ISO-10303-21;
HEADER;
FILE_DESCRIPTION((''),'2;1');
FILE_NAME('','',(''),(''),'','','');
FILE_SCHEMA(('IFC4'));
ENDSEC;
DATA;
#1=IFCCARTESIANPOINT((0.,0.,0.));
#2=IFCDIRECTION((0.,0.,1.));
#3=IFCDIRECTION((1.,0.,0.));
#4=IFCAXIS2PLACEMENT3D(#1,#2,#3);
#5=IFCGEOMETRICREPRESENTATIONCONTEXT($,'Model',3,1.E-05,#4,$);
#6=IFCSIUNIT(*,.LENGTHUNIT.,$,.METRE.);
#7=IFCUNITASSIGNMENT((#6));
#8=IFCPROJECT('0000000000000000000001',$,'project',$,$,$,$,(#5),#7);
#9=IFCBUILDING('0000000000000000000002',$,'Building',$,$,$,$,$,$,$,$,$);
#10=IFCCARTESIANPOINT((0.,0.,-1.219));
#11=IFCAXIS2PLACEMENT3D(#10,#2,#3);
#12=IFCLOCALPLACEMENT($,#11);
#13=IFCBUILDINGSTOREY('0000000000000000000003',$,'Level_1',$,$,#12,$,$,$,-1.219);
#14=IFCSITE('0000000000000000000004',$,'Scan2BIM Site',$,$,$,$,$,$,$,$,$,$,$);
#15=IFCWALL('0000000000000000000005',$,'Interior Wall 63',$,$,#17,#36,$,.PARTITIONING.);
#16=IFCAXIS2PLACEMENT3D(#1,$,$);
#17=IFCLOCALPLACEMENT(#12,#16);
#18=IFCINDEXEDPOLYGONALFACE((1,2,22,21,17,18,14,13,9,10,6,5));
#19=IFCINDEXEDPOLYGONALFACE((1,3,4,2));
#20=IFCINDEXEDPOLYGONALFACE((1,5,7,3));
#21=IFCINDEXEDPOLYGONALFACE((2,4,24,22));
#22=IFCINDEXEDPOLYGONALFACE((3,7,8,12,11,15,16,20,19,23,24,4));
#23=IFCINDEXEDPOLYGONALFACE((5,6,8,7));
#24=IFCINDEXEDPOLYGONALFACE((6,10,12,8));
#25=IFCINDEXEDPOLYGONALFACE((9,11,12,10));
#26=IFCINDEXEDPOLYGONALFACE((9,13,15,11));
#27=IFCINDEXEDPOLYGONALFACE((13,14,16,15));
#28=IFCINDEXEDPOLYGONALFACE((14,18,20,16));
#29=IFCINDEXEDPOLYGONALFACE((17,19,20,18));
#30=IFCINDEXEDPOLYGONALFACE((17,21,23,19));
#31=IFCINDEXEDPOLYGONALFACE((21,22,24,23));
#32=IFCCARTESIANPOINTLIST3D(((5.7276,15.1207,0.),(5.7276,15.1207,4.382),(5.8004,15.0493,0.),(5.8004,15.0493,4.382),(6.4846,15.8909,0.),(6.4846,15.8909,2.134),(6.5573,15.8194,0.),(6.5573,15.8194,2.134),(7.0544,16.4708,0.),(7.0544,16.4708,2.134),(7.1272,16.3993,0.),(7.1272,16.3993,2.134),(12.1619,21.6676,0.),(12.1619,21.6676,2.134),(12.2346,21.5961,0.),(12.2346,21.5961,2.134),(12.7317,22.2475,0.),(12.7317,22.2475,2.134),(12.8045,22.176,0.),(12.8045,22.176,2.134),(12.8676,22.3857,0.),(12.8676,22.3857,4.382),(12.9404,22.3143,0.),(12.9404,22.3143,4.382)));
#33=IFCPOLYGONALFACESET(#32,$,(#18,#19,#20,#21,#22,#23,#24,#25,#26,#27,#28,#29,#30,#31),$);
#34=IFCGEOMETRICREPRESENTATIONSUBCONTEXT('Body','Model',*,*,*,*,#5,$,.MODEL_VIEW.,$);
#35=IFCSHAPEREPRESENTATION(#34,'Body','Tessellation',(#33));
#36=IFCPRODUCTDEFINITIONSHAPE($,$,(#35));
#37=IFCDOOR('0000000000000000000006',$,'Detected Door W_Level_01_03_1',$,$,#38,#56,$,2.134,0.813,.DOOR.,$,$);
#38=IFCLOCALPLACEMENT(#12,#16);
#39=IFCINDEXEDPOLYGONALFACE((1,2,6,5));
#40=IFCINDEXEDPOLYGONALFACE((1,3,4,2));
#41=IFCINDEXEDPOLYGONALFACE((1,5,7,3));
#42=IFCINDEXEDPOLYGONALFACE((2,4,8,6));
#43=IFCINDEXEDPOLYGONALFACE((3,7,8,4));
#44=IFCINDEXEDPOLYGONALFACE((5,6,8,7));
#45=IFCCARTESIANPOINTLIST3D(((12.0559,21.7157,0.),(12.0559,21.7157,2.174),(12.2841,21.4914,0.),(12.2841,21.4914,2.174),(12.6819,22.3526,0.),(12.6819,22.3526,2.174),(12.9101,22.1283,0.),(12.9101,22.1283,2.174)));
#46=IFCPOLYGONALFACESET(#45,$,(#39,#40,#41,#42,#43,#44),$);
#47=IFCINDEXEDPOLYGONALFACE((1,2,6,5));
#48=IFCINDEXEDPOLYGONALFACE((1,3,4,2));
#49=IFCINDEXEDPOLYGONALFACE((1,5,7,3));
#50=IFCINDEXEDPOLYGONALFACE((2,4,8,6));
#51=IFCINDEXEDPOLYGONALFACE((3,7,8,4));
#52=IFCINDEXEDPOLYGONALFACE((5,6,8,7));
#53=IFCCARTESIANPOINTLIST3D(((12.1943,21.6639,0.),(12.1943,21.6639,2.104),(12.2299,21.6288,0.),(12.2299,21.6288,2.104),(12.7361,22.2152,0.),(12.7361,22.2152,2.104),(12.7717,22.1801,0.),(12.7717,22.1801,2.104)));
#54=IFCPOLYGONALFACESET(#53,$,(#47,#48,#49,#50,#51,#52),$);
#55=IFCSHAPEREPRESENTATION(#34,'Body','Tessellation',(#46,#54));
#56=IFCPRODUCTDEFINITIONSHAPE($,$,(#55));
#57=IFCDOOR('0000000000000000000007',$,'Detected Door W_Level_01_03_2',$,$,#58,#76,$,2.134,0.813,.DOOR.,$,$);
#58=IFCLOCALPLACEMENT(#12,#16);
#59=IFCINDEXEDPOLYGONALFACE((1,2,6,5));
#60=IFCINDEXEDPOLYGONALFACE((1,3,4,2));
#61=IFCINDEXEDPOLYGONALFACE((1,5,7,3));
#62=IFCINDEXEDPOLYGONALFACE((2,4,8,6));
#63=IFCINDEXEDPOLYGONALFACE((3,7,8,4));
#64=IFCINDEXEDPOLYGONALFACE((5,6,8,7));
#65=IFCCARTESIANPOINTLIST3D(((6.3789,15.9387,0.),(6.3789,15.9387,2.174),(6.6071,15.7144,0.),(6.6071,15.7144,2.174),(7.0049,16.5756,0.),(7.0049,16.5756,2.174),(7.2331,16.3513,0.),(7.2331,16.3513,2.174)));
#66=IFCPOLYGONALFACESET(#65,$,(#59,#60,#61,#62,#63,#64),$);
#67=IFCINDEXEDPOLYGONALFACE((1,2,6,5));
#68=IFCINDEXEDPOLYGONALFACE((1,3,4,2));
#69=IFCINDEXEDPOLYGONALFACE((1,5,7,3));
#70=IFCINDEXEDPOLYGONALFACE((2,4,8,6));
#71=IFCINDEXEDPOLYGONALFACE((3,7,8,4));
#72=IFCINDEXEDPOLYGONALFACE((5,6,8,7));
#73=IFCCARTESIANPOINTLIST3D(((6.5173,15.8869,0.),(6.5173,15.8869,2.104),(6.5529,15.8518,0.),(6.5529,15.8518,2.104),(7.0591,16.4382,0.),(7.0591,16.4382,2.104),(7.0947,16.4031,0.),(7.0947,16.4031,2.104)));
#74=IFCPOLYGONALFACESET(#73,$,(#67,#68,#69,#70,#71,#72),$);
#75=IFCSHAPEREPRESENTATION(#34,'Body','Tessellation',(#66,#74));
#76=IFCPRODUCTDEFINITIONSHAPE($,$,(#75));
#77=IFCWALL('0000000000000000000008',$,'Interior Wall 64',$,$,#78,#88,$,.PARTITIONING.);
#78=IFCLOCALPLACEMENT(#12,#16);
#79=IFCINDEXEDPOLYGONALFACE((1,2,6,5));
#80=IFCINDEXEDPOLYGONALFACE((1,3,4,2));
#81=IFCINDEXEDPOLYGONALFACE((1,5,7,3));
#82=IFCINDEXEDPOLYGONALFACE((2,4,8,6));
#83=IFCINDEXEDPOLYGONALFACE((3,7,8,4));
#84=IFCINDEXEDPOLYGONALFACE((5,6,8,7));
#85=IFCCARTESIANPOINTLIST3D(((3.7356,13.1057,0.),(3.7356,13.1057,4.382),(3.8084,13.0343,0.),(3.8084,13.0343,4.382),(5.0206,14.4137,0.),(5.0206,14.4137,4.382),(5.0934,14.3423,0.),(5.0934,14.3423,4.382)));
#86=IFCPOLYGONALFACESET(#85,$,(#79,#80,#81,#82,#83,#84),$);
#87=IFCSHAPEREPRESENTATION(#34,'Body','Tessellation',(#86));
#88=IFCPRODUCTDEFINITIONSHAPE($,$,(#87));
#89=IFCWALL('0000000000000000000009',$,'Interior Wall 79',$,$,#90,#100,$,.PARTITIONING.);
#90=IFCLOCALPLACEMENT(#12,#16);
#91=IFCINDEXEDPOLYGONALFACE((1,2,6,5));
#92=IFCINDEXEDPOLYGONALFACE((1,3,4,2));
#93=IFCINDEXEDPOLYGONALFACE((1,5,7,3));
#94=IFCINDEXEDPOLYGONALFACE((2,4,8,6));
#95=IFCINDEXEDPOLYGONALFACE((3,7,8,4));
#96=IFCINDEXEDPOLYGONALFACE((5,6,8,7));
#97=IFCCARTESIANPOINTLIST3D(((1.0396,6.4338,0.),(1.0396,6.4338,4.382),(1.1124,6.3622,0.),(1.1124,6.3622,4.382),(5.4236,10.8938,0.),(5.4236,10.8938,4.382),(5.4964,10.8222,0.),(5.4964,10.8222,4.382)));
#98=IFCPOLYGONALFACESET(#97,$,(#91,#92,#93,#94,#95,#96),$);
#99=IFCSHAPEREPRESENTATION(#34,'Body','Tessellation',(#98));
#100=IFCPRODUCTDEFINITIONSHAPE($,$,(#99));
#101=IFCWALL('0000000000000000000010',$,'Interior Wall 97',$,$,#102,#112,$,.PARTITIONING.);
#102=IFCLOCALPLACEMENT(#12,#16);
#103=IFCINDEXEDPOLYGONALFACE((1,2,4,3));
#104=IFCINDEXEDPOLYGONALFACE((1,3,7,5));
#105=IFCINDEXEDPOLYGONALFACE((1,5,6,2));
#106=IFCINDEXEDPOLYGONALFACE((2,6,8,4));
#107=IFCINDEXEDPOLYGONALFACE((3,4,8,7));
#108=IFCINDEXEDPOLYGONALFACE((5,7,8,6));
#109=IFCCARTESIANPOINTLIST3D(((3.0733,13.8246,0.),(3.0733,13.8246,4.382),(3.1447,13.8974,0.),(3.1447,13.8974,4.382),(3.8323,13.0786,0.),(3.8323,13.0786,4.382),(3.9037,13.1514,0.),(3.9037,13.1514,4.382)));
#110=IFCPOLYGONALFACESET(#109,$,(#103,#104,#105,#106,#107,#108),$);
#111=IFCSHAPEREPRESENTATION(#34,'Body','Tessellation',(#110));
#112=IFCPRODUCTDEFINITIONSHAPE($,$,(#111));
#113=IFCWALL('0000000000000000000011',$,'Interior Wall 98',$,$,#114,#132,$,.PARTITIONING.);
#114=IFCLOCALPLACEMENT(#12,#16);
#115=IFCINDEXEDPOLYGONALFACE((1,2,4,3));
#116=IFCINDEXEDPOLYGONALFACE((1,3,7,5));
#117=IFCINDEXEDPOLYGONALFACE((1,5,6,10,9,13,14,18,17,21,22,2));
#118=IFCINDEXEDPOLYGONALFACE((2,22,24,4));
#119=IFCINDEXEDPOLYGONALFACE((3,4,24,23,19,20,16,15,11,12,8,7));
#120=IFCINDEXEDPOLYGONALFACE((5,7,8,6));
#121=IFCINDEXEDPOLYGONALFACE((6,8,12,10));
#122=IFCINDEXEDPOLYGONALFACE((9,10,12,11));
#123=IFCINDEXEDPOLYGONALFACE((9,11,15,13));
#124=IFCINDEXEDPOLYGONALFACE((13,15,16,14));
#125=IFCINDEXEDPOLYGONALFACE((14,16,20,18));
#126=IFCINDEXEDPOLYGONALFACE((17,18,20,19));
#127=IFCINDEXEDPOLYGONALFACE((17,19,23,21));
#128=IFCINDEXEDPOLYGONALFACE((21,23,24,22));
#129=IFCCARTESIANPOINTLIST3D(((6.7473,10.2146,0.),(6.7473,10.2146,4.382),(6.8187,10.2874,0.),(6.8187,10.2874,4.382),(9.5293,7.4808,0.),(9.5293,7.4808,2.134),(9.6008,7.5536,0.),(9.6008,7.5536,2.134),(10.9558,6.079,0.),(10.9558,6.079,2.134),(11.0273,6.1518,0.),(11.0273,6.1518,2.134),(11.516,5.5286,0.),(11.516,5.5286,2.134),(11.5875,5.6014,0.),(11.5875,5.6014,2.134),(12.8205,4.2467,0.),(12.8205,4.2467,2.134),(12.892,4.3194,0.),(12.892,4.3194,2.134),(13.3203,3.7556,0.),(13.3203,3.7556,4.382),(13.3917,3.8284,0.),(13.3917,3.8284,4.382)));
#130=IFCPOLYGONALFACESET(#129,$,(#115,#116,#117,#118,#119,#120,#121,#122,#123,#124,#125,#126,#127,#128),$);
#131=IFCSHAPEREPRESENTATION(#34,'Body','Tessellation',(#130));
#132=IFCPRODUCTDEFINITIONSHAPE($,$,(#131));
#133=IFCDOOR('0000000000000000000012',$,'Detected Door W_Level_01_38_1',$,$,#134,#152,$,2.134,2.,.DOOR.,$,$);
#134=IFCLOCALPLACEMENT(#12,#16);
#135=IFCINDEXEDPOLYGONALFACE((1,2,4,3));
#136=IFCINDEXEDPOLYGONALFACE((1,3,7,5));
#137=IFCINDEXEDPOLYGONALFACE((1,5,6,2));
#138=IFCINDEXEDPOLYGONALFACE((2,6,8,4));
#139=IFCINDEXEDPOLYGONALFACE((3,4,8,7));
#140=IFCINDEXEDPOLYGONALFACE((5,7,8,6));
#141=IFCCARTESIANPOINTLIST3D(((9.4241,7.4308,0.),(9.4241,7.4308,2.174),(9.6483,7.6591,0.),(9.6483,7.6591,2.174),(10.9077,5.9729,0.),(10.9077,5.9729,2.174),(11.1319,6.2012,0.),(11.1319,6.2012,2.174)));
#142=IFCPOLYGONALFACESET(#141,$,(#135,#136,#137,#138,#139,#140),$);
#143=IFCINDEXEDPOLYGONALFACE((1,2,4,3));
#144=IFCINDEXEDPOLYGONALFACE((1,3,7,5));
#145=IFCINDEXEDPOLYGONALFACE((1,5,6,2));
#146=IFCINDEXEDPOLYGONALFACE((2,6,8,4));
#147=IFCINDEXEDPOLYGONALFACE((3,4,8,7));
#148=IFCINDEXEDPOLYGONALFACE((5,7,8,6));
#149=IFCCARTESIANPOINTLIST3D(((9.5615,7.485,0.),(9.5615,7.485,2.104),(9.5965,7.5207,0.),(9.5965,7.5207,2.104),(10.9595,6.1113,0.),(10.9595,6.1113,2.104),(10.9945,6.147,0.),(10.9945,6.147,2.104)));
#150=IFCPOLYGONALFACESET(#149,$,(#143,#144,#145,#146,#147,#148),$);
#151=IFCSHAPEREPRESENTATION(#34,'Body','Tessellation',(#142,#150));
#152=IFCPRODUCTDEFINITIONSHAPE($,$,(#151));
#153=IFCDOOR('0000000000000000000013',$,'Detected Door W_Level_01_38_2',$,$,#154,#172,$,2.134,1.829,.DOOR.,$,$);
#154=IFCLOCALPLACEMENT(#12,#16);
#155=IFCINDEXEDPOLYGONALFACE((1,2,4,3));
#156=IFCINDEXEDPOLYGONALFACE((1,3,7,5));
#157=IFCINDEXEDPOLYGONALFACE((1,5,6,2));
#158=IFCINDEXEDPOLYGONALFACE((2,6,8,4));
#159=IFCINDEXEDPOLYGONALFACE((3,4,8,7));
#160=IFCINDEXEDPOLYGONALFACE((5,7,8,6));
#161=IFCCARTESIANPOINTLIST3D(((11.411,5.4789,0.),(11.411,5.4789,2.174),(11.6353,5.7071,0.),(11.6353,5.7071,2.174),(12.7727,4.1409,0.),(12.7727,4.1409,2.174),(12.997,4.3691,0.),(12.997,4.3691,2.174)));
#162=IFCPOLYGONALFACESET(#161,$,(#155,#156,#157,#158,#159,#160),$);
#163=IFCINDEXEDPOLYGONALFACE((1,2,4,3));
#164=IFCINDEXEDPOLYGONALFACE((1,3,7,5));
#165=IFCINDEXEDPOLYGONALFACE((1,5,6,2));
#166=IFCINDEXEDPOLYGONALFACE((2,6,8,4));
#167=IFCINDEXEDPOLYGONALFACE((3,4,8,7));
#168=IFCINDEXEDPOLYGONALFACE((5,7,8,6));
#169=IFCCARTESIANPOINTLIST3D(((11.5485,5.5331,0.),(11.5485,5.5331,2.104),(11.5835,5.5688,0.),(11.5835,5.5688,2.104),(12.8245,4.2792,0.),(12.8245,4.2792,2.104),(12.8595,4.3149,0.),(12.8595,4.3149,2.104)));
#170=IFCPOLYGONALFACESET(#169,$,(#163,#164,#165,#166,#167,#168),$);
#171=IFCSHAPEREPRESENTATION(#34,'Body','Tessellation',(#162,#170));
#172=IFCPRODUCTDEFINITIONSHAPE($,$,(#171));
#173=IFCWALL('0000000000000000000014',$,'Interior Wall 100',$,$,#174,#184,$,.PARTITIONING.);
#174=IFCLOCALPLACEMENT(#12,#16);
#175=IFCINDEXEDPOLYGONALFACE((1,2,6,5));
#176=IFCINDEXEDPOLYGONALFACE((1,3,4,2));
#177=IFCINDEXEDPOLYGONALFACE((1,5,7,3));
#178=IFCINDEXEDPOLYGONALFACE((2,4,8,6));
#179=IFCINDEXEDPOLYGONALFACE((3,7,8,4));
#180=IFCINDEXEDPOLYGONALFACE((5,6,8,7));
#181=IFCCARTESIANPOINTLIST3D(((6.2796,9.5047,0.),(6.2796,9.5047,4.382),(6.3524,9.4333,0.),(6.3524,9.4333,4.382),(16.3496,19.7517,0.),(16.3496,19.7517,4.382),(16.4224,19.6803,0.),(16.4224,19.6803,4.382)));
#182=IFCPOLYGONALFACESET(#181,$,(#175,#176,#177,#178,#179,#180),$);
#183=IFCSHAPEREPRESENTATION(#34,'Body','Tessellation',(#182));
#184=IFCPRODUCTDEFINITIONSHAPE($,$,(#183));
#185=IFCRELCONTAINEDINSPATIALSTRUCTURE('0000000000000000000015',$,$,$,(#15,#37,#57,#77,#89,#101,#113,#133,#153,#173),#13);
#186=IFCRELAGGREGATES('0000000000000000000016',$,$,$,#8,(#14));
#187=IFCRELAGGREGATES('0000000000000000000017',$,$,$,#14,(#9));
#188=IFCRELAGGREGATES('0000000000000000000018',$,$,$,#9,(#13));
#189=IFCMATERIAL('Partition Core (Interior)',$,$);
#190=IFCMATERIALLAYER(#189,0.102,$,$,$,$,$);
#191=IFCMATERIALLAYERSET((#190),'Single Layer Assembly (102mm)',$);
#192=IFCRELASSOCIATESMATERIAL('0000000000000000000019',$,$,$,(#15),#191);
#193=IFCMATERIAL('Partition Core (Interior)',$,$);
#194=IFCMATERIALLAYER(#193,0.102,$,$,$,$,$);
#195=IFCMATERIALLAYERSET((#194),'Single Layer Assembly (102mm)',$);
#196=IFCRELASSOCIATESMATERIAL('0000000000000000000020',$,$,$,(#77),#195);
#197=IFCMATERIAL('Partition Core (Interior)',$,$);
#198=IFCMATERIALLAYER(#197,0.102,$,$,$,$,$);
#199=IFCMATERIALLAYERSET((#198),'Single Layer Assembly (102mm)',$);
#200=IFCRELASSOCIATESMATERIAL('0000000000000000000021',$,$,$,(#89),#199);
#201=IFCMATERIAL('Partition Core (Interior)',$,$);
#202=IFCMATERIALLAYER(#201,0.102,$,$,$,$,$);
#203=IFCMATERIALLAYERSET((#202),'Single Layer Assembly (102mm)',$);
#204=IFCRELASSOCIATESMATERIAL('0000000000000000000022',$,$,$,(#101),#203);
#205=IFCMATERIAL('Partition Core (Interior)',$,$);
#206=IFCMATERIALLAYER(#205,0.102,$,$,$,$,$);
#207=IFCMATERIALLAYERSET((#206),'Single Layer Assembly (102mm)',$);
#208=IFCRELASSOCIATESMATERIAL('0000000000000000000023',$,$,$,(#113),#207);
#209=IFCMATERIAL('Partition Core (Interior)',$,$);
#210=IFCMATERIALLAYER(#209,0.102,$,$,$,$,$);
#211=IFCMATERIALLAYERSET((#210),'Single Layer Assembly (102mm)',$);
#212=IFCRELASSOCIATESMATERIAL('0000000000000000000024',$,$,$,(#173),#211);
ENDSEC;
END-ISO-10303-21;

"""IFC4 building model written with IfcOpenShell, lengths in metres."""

from ifc_helpers import new_model, si_unit, frame, origin, origin_with_axes, place, context, subcontext, project, spatial, rectangle, extrude, material, layer, layer_set, element, fill, save


model = new_model("IFC4")

# Units and contexts
model_context = context("Model", 3, precision=1e-05, world=origin_with_axes())
body_context = subcontext(model_context, "Body", "Model", "MODEL_VIEW")
ifc_project = project(units=[si_unit("LENGTHUNIT", "METRE")], contexts=[model_context])

# Site, building, storey
site = spatial("IfcSite", under=ifc_project, Name="Scan2BIM Site")
building = spatial("IfcBuilding", under=site, Name="Building")
storey_placement = place(None, frame((0.0, 0.0, -1.219), z_axis=(0.0, 0.0, 1.0), x_axis=(1.0, 0.0, 0.0)))
storey = spatial("IfcBuildingStorey", under=building, at=storey_placement, Name="Level_1", Elevation=-1.219)

# Wall, openings, doors
ifc_material_1 = material(Name="Partition Core (Interior)")
ifc_layer_1 = layer(ifc_material_1, 0.102)
ifc_layer_set_1 = layer_set([ifc_layer_1], Name="Single Layer Assembly (102mm)")
wall_1_placement = place(storey_placement, frame((9.334, 18.7175, 0.0), z_axis=(0.0, 0.0, 1.0), x_axis=(-0.700944, -0.713216, 0.0)))
wall_1 = element("IfcWall", 1, at=wall_1_placement, inside=storey, material=ifc_layer_set_1, Name="Interior Wall 63", PredefinedType="PARTITIONING", context=body_context, shape_type="SweptSolid", body=[
    extrude(rectangle(XDim=10.1863, YDim=0.102), origin(), (0.0, 0.0, 1.0), 4.382),
])
opening_1_placement = place(None, frame((12.483, 21.922, -1.219), z_axis=(0.0, 0.0, 1.0), x_axis=(-0.700944, -0.713216, 0.0)))
opening_1 = element("IfcOpeningElement", 2, at=opening_1_placement, cuts=wall_1, PredefinedType="OPENING", context=body_context, shape_type="SweptSolid", body=[
    extrude(rectangle(XDim=0.813, YDim=0.202), origin(), (0.0, 0.0, 1.0), 2.134),
])
opening_2_placement = place(None, frame((6.806, 16.145, -1.219), z_axis=(0.0, 0.0, 1.0), x_axis=(-0.700944, -0.713216, 0.0)))
opening_2 = element("IfcOpeningElement", 3, at=opening_2_placement, cuts=wall_1, PredefinedType="OPENING", context=body_context, shape_type="SweptSolid", body=[
    extrude(rectangle(XDim=0.813, YDim=0.202), origin(), (0.0, 0.0, 1.0), 2.134),
])
door_1_placement = place(opening_1_placement, frame((0.0, 0.0, 0.0), z_axis=(0.0, 0.0, 1.0), x_axis=(1.0, 0.0, 0.0)))
door_1 = element("IfcDoor", 4, at=door_1_placement, inside=storey, Name="Detected Door W_Level_01_03_1", OverallHeight=2.134, OverallWidth=0.813, PredefinedType="DOOR", context=body_context, shape_type="SweptSolid", body=[
    extrude(rectangle(XDim=0.893, YDim=0.32), origin(), (0.0, 0.0, 1.0), 2.174),
    extrude(rectangle(XDim=0.773, YDim=0.05), origin(), (0.0, 0.0, 1.0), 2.104),
])
fill(opening_1, door_1)
door_2_placement = place(opening_2_placement, frame((0.0, 0.0, 0.0), z_axis=(0.0, 0.0, 1.0), x_axis=(1.0, 0.0, 0.0)))
door_2 = element("IfcDoor", 5, at=door_2_placement, inside=storey, Name="Detected Door W_Level_01_03_2", OverallHeight=2.134, OverallWidth=0.813, PredefinedType="DOOR", context=body_context, shape_type="SweptSolid", body=[
    extrude(rectangle(XDim=0.893, YDim=0.32), origin(), (0.0, 0.0, 1.0), 2.174),
    extrude(rectangle(XDim=0.773, YDim=0.05), origin(), (0.0, 0.0, 1.0), 2.104),
])
fill(opening_2, door_2)

# Walls
ifc_material_2 = material(Name="Partition Core (Interior)")
ifc_layer_2 = layer(ifc_material_2, 0.102)
ifc_layer_set_2 = layer_set([ifc_layer_2], Name="Single Layer Assembly (102mm)")
wall_2_placement = place(storey_placement, frame((4.4145, 13.724, 0.0), z_axis=(0.0, 0.0, 1.0), x_axis=(-0.700807, -0.713351, 0.0)))
element("IfcWall", 6, at=wall_2_placement, inside=storey, material=ifc_layer_set_2, Name="Interior Wall 64", PredefinedType="PARTITIONING", context=body_context, shape_type="SweptSolid", body=[
    extrude(rectangle(XDim=1.8336, YDim=0.102), origin(), (0.0, 0.0, 1.0), 4.382),
])
ifc_material_3 = material(Name="Partition Core (Interior)")
ifc_layer_3 = layer(ifc_material_3, 0.102)
ifc_layer_set_3 = layer_set([ifc_layer_3], Name="Single Layer Assembly (102mm)")
wall_3_placement = place(storey_placement, frame((3.268, 8.628, 0.0), z_axis=(0.0, 0.0, 1.0), x_axis=(0.701004, 0.713157, 0.0)))
element("IfcWall", 7, at=wall_3_placement, inside=storey, material=ifc_layer_set_3, Name="Interior Wall 79", PredefinedType="PARTITIONING", context=body_context, shape_type="SweptSolid", body=[
    extrude(rectangle(XDim=6.2539, YDim=0.102), origin(), (0.0, 0.0, 1.0), 4.382),
])
ifc_material_4 = material(Name="Partition Core (Interior)")
ifc_layer_4 = layer(ifc_material_4, 0.102)
ifc_layer_set_4 = layer_set([ifc_layer_4], Name="Single Layer Assembly (102mm)")
wall_4_placement = place(storey_placement, frame((3.4885, 13.488, 0.0), z_axis=(0.0, 0.0, 1.0), x_axis=(0.713188, -0.700973, 0.0)))
element("IfcWall", 8, at=wall_4_placement, inside=storey, material=ifc_layer_set_4, Name="Interior Wall 97", PredefinedType="PARTITIONING", context=body_context, shape_type="SweptSolid", body=[
    extrude(rectangle(XDim=1.0642, YDim=0.102), origin(), (0.0, 0.0, 1.0), 4.382),
])

# Wall, openings, doors
ifc_material_5 = material(Name="Partition Core (Interior)")
ifc_layer_5 = layer(ifc_material_5, 0.102)
ifc_layer_set_5 = layer_set([ifc_layer_5], Name="Single Layer Assembly (102mm)")
wall_5_placement = place(storey_placement, frame((10.0695, 7.0215, 0.0), z_axis=(0.0, 0.0, 1.0), x_axis=(0.713265, -0.700894, 0.0)))
wall_5 = element("IfcWall", 9, at=wall_5_placement, inside=storey, material=ifc_layer_set_5, Name="Interior Wall 98", PredefinedType="PARTITIONING", context=body_context, shape_type="SweptSolid", body=[
    extrude(rectangle(XDim=9.2154, YDim=0.102), origin(), (0.0, 0.0, 1.0), 4.382),
])
opening_3_placement = place(None, frame((10.278, 6.816, -1.219), z_axis=(0.0, 0.0, 1.0), x_axis=(0.713265, -0.700894, 0.0)))
opening_3 = element("IfcOpeningElement", 10, at=opening_3_placement, cuts=wall_5, PredefinedType="OPENING", context=body_context, shape_type="SweptSolid", body=[
    extrude(rectangle(XDim=2.0, YDim=0.202), origin(), (0.0, 0.0, 1.0), 2.134),
])
opening_4_placement = place(None, frame((12.204, 4.924, -1.219), z_axis=(0.0, 0.0, 1.0), x_axis=(0.713265, -0.700894, 0.0)))
opening_4 = element("IfcOpeningElement", 11, at=opening_4_placement, cuts=wall_5, PredefinedType="OPENING", context=body_context, shape_type="SweptSolid", body=[
    extrude(rectangle(XDim=1.829, YDim=0.202), origin(), (0.0, 0.0, 1.0), 2.134),
])
door_3_placement = place(opening_3_placement, frame((0.0, 0.0, 0.0), z_axis=(0.0, 0.0, 1.0), x_axis=(1.0, 0.0, 0.0)))
door_3 = element("IfcDoor", 12, at=door_3_placement, inside=storey, Name="Detected Door W_Level_01_38_1", OverallHeight=2.134, OverallWidth=2.0, PredefinedType="DOOR", context=body_context, shape_type="SweptSolid", body=[
    extrude(rectangle(XDim=2.08, YDim=0.32), origin(), (0.0, 0.0, 1.0), 2.174),
    extrude(rectangle(XDim=1.96, YDim=0.05), origin(), (0.0, 0.0, 1.0), 2.104),
])
fill(opening_3, door_3)
door_4_placement = place(opening_4_placement, frame((0.0, 0.0, 0.0), z_axis=(0.0, 0.0, 1.0), x_axis=(1.0, 0.0, 0.0)))
door_4 = element("IfcDoor", 13, at=door_4_placement, inside=storey, Name="Detected Door W_Level_01_38_2", OverallHeight=2.134, OverallWidth=1.829, PredefinedType="DOOR", context=body_context, shape_type="SweptSolid", body=[
    extrude(rectangle(XDim=1.909, YDim=0.32), origin(), (0.0, 0.0, 1.0), 2.174),
    extrude(rectangle(XDim=1.789, YDim=0.05), origin(), (0.0, 0.0, 1.0), 2.104),
])
fill(opening_4, door_4)

# Wall
ifc_material_6 = material(Name="Partition Core (Interior)")
ifc_layer_6 = layer(ifc_material_6, 0.102)
ifc_layer_set_6 = layer_set([ifc_layer_6], Name="Single Layer Assembly (102mm)")
wall_6_placement = place(storey_placement, frame((11.351, 14.5925, 0.0), z_axis=(0.0, 0.0, 1.0), x_axis=(-0.70092, -0.71324, 0.0)))
element("IfcWall", 14, at=wall_6_placement, inside=storey, material=ifc_layer_set_6, Name="Interior Wall 100", PredefinedType="PARTITIONING", context=body_context, shape_type="SweptSolid", body=[
    extrude(rectangle(XDim=14.3668, YDim=0.102), origin(), (0.0, 0.0, 1.0), 4.382),
])

save(model, "model.ifc")
